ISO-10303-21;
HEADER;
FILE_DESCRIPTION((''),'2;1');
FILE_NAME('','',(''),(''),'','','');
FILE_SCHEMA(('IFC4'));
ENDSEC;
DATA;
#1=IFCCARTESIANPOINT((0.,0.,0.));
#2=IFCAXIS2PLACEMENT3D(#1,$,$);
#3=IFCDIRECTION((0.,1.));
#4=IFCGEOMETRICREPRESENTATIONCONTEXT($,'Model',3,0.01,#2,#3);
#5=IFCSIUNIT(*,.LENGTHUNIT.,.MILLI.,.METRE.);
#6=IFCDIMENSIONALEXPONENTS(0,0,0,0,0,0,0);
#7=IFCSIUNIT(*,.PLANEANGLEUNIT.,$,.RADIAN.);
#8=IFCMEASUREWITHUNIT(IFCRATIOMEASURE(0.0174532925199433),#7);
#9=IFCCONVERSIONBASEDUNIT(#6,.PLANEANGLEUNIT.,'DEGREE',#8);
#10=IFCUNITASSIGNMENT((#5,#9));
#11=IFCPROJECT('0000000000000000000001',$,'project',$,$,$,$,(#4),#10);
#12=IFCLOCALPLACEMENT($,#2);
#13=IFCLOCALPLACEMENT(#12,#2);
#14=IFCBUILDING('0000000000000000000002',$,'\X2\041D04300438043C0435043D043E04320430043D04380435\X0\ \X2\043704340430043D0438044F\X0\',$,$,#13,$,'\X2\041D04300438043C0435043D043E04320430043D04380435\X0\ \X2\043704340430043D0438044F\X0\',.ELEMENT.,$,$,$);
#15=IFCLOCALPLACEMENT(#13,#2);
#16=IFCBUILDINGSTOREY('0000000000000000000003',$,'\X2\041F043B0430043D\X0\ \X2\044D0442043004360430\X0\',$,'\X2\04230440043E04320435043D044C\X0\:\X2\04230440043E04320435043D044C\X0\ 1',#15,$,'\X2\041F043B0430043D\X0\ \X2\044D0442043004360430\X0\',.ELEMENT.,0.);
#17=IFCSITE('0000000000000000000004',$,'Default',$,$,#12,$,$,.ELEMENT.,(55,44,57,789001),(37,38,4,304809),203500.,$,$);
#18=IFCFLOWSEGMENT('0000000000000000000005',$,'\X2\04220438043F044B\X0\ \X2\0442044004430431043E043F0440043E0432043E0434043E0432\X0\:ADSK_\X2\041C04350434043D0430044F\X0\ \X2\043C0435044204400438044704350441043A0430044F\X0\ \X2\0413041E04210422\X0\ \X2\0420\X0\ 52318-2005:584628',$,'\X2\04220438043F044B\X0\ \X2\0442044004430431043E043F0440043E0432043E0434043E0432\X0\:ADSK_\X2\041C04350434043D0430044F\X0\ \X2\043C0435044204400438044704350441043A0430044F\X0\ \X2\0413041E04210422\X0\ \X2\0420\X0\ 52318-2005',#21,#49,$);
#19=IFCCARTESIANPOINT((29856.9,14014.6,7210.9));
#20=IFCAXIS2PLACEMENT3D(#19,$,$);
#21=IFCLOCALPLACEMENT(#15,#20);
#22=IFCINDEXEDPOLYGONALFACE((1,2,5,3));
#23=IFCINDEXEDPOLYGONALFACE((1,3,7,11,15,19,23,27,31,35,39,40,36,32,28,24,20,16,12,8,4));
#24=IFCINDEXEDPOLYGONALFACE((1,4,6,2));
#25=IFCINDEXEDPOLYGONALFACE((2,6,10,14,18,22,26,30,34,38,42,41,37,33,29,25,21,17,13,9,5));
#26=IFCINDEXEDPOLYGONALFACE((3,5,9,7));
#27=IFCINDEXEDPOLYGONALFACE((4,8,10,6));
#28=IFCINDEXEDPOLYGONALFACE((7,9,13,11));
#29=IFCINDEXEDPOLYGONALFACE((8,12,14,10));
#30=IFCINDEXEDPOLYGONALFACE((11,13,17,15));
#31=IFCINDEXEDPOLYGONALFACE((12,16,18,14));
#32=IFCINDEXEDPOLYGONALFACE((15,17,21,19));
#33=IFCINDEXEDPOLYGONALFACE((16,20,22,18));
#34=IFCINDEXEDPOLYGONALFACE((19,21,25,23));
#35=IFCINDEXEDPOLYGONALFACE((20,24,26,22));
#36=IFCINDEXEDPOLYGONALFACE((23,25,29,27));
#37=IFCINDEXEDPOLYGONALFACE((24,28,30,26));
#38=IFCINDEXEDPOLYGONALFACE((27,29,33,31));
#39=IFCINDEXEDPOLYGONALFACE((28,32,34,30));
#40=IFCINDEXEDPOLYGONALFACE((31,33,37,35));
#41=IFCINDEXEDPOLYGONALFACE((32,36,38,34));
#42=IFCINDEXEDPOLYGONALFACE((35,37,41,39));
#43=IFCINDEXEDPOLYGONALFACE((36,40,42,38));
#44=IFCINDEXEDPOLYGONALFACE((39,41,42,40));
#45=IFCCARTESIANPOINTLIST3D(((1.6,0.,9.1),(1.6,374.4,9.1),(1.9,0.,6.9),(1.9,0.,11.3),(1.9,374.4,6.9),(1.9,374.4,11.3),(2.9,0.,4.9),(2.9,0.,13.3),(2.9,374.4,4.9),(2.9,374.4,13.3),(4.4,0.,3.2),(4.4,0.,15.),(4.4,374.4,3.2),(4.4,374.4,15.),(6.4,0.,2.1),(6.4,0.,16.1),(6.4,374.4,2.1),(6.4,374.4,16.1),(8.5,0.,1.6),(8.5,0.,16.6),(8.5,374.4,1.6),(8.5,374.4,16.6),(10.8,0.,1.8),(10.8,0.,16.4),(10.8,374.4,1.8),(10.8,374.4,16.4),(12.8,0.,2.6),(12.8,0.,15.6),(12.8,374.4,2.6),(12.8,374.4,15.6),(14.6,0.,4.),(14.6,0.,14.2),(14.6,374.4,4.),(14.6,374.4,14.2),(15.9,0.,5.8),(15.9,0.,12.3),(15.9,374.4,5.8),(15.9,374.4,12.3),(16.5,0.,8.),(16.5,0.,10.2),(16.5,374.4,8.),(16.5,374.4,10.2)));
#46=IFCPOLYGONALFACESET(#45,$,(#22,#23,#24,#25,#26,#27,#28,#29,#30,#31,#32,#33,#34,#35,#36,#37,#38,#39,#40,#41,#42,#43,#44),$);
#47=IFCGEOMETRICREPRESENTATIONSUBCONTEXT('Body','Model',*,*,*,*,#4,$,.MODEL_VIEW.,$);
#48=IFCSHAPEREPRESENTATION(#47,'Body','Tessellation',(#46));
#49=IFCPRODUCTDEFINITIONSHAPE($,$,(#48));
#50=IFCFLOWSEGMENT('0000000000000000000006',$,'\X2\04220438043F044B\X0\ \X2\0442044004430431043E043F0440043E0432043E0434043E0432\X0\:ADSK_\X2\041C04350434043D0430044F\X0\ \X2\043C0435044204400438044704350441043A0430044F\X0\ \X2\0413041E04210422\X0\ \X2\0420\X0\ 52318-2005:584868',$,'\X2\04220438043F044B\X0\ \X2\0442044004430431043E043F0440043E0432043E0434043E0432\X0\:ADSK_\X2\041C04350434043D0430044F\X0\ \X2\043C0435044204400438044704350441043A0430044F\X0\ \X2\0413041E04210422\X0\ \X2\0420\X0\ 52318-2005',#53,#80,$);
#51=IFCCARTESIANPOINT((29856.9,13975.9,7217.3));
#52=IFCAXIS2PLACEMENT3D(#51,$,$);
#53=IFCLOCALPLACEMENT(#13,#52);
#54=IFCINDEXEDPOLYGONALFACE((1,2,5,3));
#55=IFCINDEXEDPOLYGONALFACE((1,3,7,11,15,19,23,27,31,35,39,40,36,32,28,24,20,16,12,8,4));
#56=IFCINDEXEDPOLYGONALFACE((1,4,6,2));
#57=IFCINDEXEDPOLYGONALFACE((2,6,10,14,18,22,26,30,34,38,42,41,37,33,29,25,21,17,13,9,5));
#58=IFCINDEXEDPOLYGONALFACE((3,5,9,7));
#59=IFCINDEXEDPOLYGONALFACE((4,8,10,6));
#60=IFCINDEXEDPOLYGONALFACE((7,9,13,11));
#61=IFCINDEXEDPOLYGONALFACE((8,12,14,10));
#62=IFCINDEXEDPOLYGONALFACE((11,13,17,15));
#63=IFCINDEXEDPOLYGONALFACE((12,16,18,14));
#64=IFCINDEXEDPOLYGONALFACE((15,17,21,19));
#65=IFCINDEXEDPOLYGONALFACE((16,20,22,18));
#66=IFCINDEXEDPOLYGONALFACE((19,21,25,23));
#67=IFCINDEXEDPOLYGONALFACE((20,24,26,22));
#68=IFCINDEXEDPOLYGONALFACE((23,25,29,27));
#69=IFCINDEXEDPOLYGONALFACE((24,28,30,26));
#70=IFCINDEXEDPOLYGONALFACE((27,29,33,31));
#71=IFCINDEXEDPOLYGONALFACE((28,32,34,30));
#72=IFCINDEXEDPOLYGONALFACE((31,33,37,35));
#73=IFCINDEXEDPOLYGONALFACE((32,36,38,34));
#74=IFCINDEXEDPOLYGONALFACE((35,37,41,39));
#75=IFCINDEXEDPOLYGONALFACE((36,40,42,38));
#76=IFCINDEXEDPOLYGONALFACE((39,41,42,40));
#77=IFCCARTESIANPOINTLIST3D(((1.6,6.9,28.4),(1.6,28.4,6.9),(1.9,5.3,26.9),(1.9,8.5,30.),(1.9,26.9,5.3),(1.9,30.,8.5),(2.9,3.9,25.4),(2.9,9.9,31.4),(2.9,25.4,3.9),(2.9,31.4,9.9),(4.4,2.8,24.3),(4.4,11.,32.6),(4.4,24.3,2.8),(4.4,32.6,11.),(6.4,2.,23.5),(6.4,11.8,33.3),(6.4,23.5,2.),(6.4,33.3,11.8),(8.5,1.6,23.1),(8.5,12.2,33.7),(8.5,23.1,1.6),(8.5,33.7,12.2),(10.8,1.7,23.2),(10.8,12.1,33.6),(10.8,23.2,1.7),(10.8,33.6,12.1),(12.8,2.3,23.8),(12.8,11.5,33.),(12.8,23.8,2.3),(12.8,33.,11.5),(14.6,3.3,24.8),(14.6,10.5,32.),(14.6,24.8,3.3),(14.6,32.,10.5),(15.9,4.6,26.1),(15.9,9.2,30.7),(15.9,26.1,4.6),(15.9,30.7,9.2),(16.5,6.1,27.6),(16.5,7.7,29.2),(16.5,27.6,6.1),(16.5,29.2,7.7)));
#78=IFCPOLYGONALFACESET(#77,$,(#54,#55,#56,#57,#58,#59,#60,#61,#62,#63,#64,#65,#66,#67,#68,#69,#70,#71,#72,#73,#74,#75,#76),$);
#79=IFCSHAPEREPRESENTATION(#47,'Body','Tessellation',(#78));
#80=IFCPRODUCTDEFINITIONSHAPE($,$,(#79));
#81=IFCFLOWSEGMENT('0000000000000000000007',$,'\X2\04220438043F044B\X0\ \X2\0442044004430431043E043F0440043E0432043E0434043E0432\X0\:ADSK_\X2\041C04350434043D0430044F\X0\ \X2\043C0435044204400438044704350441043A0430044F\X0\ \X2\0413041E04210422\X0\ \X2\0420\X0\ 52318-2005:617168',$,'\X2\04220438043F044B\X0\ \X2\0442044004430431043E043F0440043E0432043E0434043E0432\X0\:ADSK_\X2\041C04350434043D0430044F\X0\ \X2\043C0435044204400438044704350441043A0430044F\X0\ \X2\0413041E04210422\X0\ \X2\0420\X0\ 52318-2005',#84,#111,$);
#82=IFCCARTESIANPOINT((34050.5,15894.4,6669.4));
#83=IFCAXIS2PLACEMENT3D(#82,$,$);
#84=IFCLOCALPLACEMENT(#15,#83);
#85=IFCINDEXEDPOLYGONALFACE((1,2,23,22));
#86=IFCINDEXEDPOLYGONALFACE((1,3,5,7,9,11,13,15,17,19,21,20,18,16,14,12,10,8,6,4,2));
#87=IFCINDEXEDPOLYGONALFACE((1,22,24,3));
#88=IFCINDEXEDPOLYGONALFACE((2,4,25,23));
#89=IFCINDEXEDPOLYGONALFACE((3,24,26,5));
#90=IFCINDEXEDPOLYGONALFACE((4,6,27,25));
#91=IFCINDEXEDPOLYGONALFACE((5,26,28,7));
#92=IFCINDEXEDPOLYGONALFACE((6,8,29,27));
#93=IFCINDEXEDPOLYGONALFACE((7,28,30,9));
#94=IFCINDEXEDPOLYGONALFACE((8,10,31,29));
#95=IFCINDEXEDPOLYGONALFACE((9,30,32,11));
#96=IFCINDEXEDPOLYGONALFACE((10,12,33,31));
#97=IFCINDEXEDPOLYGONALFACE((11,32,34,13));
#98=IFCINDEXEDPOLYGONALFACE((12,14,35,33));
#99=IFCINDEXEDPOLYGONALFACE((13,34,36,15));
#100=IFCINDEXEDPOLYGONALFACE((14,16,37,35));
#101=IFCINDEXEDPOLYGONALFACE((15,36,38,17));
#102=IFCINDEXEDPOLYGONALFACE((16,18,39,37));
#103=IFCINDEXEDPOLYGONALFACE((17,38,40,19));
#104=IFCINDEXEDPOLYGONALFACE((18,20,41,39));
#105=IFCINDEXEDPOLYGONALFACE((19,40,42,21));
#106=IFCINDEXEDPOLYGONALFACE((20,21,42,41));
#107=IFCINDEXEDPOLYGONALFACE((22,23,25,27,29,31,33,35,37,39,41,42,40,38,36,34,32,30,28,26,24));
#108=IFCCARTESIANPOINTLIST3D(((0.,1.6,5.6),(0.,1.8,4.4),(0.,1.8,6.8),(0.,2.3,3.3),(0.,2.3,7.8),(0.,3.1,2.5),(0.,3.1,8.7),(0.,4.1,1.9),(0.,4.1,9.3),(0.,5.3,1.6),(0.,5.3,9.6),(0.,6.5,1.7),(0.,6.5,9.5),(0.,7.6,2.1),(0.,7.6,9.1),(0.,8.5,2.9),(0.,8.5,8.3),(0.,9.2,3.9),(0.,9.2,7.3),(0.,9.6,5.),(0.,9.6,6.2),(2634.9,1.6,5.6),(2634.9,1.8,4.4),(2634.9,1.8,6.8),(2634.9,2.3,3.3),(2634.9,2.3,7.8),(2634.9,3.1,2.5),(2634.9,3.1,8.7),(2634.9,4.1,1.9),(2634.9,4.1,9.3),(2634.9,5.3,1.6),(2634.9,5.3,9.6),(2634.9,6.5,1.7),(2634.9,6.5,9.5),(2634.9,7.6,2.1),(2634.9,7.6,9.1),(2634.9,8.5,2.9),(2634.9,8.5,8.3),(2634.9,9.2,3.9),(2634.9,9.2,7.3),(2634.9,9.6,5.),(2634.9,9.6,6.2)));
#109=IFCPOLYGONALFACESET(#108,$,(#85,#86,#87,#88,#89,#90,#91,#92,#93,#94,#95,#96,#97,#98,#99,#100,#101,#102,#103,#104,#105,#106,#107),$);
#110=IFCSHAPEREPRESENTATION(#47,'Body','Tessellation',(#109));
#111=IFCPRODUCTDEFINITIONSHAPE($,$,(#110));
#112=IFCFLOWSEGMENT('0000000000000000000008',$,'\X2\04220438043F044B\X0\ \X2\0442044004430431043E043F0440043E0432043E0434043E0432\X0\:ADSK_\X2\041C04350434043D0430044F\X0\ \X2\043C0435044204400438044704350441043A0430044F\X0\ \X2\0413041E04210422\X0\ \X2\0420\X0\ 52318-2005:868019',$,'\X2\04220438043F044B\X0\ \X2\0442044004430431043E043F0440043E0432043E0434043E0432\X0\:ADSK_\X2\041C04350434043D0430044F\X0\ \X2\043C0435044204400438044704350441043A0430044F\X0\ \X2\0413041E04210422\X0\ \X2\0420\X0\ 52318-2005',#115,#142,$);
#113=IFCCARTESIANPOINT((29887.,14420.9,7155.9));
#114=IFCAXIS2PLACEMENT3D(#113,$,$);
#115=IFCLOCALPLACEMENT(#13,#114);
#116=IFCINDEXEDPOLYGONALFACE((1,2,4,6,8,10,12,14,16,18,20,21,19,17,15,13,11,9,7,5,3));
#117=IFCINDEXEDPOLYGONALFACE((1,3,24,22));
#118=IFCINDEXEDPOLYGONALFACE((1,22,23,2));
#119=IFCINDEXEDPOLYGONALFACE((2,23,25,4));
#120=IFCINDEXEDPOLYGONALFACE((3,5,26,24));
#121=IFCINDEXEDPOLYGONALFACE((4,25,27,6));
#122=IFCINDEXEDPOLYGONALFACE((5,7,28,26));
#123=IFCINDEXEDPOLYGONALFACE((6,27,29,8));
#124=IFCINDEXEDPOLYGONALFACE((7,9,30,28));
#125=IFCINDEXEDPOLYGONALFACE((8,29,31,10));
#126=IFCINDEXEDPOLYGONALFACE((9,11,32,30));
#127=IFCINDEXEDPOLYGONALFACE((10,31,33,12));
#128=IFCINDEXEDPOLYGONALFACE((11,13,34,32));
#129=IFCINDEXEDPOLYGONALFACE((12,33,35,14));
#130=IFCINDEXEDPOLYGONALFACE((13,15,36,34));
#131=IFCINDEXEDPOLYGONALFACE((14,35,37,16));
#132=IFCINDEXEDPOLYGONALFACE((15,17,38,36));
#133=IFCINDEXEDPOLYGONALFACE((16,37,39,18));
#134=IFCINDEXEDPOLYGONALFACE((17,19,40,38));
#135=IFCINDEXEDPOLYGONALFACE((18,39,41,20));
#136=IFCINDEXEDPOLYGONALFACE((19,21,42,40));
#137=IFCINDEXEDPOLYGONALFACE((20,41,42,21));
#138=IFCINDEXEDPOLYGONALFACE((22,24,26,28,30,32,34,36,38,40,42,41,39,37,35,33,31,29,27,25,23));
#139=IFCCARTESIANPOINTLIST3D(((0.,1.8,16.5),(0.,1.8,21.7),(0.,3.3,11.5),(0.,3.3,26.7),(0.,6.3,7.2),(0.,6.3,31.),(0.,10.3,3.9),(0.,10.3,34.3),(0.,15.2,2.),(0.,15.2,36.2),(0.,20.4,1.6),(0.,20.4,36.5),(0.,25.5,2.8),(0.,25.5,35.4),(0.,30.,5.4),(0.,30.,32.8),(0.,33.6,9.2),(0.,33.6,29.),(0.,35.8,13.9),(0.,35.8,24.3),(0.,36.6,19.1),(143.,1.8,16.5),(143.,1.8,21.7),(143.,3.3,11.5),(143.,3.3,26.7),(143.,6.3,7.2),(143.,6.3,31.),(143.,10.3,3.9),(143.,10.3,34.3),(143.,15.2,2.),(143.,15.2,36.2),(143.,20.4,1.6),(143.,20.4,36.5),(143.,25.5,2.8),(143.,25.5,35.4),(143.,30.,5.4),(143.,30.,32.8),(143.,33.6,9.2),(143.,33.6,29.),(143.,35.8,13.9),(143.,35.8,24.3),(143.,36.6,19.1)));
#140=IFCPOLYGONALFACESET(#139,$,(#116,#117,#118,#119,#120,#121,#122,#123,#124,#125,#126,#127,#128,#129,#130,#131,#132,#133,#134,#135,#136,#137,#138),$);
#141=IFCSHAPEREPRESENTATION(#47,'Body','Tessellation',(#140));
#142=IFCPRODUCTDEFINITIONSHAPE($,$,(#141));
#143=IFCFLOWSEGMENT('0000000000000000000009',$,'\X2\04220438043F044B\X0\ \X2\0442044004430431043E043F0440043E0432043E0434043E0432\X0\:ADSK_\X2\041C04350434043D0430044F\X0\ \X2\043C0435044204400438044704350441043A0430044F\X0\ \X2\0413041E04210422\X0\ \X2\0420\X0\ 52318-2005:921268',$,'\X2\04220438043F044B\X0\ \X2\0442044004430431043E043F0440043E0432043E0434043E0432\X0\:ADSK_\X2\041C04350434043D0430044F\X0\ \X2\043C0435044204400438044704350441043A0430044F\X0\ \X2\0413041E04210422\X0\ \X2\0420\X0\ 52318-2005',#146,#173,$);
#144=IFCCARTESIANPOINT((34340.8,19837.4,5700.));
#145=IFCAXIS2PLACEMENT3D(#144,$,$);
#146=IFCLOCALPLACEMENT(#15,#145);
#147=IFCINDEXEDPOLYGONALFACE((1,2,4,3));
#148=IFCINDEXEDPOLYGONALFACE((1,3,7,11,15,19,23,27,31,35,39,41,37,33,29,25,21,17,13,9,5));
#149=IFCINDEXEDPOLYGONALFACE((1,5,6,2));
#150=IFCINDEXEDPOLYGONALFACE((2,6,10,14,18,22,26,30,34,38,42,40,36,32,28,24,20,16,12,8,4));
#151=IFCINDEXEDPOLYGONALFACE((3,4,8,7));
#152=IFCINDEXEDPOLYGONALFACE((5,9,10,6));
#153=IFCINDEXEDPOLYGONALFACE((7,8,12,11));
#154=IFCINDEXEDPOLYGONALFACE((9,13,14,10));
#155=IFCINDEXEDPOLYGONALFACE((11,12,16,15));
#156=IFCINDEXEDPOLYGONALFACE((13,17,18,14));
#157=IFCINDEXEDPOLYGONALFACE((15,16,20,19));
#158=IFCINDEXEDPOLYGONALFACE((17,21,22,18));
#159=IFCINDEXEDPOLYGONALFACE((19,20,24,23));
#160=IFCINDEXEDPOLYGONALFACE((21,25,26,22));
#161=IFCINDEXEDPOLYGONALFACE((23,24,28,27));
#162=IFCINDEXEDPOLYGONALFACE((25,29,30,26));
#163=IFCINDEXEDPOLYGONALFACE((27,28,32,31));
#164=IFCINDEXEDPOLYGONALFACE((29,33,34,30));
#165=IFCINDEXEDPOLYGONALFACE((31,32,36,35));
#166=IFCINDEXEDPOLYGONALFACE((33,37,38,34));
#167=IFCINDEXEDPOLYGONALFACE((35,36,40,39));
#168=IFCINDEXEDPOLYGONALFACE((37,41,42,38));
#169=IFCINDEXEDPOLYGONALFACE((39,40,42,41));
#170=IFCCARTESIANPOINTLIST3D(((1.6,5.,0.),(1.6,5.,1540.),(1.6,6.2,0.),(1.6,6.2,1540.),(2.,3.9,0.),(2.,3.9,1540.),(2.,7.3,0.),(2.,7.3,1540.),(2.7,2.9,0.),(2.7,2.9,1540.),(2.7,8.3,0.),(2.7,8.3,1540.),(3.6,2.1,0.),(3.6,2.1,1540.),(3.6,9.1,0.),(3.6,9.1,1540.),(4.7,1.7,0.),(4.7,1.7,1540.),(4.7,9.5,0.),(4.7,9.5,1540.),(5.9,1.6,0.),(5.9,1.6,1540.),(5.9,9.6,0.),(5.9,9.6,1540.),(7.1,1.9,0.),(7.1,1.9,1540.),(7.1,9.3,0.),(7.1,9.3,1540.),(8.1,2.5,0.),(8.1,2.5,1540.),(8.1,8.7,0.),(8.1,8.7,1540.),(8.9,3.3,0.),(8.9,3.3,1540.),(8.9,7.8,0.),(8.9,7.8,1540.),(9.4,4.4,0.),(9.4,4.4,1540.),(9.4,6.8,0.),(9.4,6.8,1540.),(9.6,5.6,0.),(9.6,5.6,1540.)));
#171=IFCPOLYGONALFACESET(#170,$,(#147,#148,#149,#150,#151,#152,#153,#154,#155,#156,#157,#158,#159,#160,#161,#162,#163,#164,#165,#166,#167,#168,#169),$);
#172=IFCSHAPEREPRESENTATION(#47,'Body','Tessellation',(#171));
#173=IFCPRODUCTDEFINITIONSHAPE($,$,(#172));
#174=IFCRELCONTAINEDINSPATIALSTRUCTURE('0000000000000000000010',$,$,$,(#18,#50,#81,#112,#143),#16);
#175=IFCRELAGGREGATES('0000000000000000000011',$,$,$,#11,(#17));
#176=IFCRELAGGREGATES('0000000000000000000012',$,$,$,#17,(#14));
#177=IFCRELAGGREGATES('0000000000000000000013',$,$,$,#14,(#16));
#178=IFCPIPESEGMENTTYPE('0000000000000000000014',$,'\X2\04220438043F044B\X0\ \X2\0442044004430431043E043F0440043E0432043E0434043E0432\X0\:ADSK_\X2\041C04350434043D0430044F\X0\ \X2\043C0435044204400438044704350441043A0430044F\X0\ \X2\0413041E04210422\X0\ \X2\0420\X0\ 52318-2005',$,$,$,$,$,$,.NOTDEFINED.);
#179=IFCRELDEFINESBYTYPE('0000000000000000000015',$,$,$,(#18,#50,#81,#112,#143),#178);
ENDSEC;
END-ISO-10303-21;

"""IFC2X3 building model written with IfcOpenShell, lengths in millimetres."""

from ifc_helpers import new_model, entity, si_unit, converted_unit, direction, frame, frame_2d, origin, origin_2d_with_axis, place, context, subcontext, project, spatial, circle, extrude, type_object, element, save


model = new_model("IFC2X3")

# Units and contexts
model_context = context("Model", 3, precision=0.01, world=origin(), true_north=direction((0.0, 1.0)))
body_context = subcontext(model_context, "Body", "Model", "MODEL_VIEW")
ifc_project = project(units=[si_unit("LENGTHUNIT", "METRE", prefix="MILLI"), converted_unit("PLANEANGLEUNIT", "DEGREE", entity("IfcRatioMeasure", 0.0174532925199433), si_unit("PLANEANGLEUNIT", "RADIAN"), dimensions=[0, 0, 0, 0, 0, 0, 0])], contexts=[model_context])

# Site, building, storey
site_placement = place(None, frame((0.0, 0.0, 0.0)))
site = spatial("IfcSite", under=ifc_project, at=site_placement, Name="Default", CompositionType="ELEMENT", RefLatitude=(55, 44, 57, 789001), RefLongitude=(37, 38, 4, 304809), RefElevation=203500.0)
building_placement = place(site_placement, origin())
building = spatial("IfcBuilding", under=site, at=building_placement, Name="Наименование здания", LongName="Наименование здания", CompositionType="ELEMENT")
storey_placement = place(building_placement, origin())
storey = spatial("IfcBuildingStorey", under=building, at=storey_placement, Name="План этажа", ObjectType="Уровень:Уровень 1", LongName="План этажа", CompositionType="ELEMENT", Elevation=0.0)

# Flow segments
pipe_segment_type = type_object("IfcPipeSegmentType", Name="Типы трубопроводов:ADSK_Медная метрическая ГОСТ Р 52318-2005", PredefinedType="NOTDEFINED")
flow_segment_1_placement = place(storey_placement, frame((29856.9, 14014.6, 7210.9)))
element("IfcFlowSegment", 1, at=flow_segment_1_placement, inside=storey, type_object=pipe_segment_type, Name="Типы трубопроводов:ADSK_Медная метрическая ГОСТ Р 52318-2005:584628", ObjectType="Типы трубопроводов:ADSK_Медная метрическая ГОСТ Р 52318-2005", context=body_context, shape_type="SweptSolid", body=[
    extrude(circle(Radius=7.5, at=frame_2d((0.0, 0.0), x_axis=(1.0, 0.0))), frame((9.1, 0.0, 9.1), z_axis=(0.0, 1.0, 0.0), x_axis=(-1.0, 0.0, 0.0)), (0.0, 0.0, 1.0), 374.4),
])
flow_segment_2_placement = place(building_placement, frame((29856.9, 13975.9, 7217.3)))
element("IfcFlowSegment", 2, at=flow_segment_2_placement, inside=storey, type_object=pipe_segment_type, Name="Типы трубопроводов:ADSK_Медная метрическая ГОСТ Р 52318-2005:584868", ObjectType="Типы трубопроводов:ADSK_Медная метрическая ГОСТ Р 52318-2005", context=body_context, shape_type="SweptSolid", body=[
    extrude(circle(Radius=7.5, at=origin_2d_with_axis()), frame((9.1, 6.9, 28.4), z_axis=(0.0, 0.707107, -0.707107), x_axis=(-1.0, 0.0, 0.0)), (0.0, 0.0, 1.0), 30.4),
])
flow_segment_3_placement = place(storey_placement, frame((34050.5, 15894.4, 6669.4)))
element("IfcFlowSegment", 3, at=flow_segment_3_placement, inside=storey, type_object=pipe_segment_type, Name="Типы трубопроводов:ADSK_Медная метрическая ГОСТ Р 52318-2005:617168", ObjectType="Типы трубопроводов:ADSK_Медная метрическая ГОСТ Р 52318-2005", context=body_context, shape_type="SweptSolid", body=[
    extrude(circle(Radius=4.0, at=frame_2d((0.0, 0.0), x_axis=(1.0, 0.0))), frame((0.0, 5.6, 5.6), z_axis=(1.0, 0.0, 0.0), x_axis=(0.0, -1.0, 0.0)), (0.0, 0.0, 1.0), 2634.9),
])
flow_segment_4_placement = place(building_placement, frame((29887.0, 14420.9, 7155.9)))
element("IfcFlowSegment", 4, at=flow_segment_4_placement, inside=storey, type_object=pipe_segment_type, Name="Типы трубопроводов:ADSK_Медная метрическая ГОСТ Р 52318-2005:868019", ObjectType="Типы трубопроводов:ADSK_Медная метрическая ГОСТ Р 52318-2005", context=body_context, shape_type="SweptSolid", body=[
    extrude(circle(Radius=17.5, at=frame_2d((0.0, 0.0), x_axis=(1.0, 0.0))), frame((0.0, 19.1, 19.1), z_axis=(1.0, 0.0, 0.0), x_axis=(0.0, 1.0, 0.0)), (0.0, 0.0, 1.0), 143.0),
])
flow_segment_5_placement = place(storey_placement, frame((34340.8, 19837.4, 5700.0)))
element("IfcFlowSegment", 5, at=flow_segment_5_placement, inside=storey, type_object=pipe_segment_type, Name="Типы трубопроводов:ADSK_Медная метрическая ГОСТ Р 52318-2005:921268", ObjectType="Типы трубопроводов:ADSK_Медная метрическая ГОСТ Р 52318-2005", context=body_context, shape_type="SweptSolid", body=[
    extrude(circle(Radius=4.0, at=origin_2d_with_axis()), frame((5.6, 5.6, 0.0)), (0.0, 0.0, 1.0), 1540.0),
])

save(model, "model.ifc")
